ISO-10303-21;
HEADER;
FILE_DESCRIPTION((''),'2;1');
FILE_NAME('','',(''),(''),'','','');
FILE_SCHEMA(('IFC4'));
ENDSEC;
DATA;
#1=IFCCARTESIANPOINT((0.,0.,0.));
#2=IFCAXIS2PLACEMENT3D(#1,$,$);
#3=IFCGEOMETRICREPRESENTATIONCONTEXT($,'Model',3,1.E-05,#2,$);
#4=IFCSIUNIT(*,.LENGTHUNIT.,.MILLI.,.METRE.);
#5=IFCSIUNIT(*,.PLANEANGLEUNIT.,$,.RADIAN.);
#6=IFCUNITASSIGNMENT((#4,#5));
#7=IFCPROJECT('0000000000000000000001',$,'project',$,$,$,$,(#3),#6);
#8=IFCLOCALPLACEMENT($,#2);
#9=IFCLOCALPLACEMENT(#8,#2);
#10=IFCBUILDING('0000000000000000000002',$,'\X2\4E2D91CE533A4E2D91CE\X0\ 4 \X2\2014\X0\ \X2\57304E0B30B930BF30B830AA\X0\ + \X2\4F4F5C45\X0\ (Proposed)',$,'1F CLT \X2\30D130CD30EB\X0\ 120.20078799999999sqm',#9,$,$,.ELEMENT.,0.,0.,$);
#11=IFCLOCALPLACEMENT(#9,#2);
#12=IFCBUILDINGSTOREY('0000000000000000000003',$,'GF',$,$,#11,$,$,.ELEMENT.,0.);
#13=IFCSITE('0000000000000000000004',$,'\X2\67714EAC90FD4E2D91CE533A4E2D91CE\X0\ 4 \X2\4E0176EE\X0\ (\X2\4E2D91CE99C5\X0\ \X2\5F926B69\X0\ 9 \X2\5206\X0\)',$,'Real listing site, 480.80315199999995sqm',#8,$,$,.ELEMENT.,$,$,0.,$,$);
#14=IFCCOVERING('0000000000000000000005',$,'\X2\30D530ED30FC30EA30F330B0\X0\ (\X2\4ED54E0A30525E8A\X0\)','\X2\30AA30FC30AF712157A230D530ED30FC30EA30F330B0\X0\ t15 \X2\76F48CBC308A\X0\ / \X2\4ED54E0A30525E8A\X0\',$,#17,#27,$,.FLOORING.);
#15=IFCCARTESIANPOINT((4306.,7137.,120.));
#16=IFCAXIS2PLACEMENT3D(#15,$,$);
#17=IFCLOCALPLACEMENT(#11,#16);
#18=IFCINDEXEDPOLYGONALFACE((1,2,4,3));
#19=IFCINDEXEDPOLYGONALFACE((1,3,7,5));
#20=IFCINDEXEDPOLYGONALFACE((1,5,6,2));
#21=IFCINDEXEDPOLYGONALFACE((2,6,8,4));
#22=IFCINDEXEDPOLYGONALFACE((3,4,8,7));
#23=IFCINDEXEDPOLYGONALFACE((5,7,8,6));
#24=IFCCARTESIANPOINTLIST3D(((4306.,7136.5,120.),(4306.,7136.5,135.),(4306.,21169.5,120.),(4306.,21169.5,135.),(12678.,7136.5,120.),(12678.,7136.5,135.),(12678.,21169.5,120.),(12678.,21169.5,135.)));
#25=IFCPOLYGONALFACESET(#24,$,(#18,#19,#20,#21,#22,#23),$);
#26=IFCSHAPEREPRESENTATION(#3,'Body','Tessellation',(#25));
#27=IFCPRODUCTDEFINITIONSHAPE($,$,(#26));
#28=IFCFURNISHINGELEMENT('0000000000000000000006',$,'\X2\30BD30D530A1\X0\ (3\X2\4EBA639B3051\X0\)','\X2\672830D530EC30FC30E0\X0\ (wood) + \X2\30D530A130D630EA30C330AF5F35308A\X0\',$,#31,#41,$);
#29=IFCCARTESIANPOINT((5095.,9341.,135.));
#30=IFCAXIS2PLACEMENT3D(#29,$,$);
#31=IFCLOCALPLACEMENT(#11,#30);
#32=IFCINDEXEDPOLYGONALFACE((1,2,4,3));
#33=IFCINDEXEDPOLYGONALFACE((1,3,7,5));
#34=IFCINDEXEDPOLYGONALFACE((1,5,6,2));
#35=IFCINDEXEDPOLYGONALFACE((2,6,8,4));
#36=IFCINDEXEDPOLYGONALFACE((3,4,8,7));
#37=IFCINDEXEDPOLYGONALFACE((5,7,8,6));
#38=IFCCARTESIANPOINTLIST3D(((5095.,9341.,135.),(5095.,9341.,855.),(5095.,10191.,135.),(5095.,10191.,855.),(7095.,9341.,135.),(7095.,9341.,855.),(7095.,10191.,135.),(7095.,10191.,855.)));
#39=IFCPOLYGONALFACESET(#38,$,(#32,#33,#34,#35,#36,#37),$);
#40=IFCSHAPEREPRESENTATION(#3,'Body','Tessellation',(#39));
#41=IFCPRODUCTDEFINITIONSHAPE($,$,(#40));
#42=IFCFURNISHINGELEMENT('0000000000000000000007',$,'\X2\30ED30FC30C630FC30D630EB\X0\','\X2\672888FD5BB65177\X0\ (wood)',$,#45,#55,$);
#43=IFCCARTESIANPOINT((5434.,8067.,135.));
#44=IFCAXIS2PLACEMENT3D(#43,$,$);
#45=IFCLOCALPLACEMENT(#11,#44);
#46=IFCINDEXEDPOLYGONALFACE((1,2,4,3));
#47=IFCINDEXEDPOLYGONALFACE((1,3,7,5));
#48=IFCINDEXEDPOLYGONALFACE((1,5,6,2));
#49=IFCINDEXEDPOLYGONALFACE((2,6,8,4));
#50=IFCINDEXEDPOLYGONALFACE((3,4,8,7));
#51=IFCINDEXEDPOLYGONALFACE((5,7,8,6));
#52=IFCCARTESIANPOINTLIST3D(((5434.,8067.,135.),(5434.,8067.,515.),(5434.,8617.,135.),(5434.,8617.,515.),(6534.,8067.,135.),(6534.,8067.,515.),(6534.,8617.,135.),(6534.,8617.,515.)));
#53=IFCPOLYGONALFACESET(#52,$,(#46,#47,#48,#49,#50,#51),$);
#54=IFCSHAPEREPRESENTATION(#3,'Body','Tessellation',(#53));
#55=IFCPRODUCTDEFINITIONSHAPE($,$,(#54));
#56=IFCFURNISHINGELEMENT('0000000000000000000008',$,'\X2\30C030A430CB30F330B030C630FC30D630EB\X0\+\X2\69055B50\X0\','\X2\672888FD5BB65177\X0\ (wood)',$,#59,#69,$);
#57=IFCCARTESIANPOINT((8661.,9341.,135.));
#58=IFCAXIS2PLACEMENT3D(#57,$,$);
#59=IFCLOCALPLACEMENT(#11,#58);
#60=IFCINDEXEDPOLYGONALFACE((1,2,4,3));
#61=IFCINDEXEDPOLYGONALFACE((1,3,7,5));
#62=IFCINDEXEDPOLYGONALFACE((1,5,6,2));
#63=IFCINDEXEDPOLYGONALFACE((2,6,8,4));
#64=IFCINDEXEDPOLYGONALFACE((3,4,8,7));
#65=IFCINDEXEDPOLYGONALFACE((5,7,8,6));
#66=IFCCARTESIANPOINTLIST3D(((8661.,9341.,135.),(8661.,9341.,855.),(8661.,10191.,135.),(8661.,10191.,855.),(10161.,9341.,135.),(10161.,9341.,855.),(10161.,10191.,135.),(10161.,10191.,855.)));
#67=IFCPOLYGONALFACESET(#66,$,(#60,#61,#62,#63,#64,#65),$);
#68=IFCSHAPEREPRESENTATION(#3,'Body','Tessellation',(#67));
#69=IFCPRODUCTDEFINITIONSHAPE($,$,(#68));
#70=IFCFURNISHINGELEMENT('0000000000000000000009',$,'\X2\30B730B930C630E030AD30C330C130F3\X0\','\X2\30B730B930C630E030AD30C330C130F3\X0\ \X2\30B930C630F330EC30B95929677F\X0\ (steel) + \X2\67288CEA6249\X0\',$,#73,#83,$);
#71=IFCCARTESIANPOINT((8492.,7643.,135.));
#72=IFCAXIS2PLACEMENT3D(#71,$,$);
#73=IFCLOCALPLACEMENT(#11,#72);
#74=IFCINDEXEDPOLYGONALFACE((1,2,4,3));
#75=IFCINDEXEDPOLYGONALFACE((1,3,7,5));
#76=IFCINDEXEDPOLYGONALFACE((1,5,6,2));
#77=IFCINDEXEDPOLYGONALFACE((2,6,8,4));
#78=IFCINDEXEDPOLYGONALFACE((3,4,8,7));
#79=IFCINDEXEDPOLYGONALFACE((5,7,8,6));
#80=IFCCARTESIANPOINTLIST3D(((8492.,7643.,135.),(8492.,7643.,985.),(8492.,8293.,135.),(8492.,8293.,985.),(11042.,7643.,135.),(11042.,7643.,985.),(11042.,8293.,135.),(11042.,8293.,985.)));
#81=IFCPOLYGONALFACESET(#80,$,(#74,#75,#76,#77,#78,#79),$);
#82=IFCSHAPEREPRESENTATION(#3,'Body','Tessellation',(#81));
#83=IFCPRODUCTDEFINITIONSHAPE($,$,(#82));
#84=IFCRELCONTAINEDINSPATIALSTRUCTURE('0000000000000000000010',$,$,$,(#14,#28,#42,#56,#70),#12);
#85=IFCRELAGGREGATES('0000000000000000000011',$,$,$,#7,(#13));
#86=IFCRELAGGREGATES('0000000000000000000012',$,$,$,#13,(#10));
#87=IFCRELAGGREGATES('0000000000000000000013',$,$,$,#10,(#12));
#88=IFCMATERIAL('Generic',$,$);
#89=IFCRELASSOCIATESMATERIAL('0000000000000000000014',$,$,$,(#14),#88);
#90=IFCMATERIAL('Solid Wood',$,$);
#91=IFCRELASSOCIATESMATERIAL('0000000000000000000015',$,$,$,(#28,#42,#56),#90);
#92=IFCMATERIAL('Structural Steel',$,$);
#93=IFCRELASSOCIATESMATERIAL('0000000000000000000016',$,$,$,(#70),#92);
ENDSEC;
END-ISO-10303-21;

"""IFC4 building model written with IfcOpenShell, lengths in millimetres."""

from ifc_helpers import new_model, si_unit, frame, frame_2d, origin, place, context, project, spatial, rectangle, extrude, material, element, save


model = new_model("IFC4")

# Units and contexts
model_context = context("Model", 3, precision=1e-05, world=origin())
ifc_project = project(units=[si_unit("LENGTHUNIT", "METRE", prefix="MILLI"), si_unit("PLANEANGLEUNIT", "RADIAN")], contexts=[model_context])

# Site, building, storey
site_placement = place(None, origin())
site = spatial("IfcSite", under=ifc_project, at=site_placement, Name="東京都中野区中野 4 丁目 (中野駅 徒歩 9 分)", ObjectType="Real listing site, 480.80315199999995sqm", CompositionType="ELEMENT", RefElevation=0.0)
building_placement = place(site_placement, origin())
building = spatial("IfcBuilding", under=site, at=building_placement, Name="中野区中野 4 — 地下スタジオ + 住居 (Proposed)", ObjectType="1F CLT パネル 120.20078799999999sqm", CompositionType="ELEMENT", ElevationOfRefHeight=0.0, ElevationOfTerrain=0.0)
storey_placement = place(building_placement, origin())
storey = spatial("IfcBuildingStorey", under=building, at=storey_placement, Name="GF", CompositionType="ELEMENT", Elevation=0.0)

# Shared definitions
ifc_material_1 = material(Name="Solid Wood")

# Shared definitions
ifc_material_2 = material(Name="Structural Steel")

# Covering
ifc_material_3 = material(Name="Generic")
covering_placement = place(storey_placement, frame((4306.0, 7137.0, 120.0)))
element("IfcCovering", 1, at=covering_placement, inside=storey, material=ifc_material_3, Name="フローリング (仕上げ床)", Description="オーク無垢フローリング t15 直貼り / 仕上げ床", PredefinedType="FLOORING", context=model_context, shape_type="SweptSolid", body=[
    extrude(rectangle(XDim=8372.0, YDim=14033.0, at=frame_2d((4186.0, 7016.0))), frame((4306.0, 7137.0, 120.0)), (0.0, 0.0, 1.0), 15.0),
])

# Furnishing elements
furnishing_1_placement = place(storey_placement, frame((5095.0, 9341.0, 135.0)))
element("IfcFurnishingElement", 2, at=furnishing_1_placement, inside=storey, material=ifc_material_1, Name="ソファ (3人掛け)", Description="木フレーム (wood) + ファブリック張り", context=model_context, shape_type="SweptSolid", body=[
    extrude(rectangle(XDim=2000.0, YDim=850.0, at=frame_2d((1000.0, 425.0))), frame((5095.0, 9341.0, 135.0)), (0.0, 0.0, 1.0), 720.0),
])
furnishing_2_placement = place(storey_placement, frame((5434.0, 8067.0, 135.0)))
element("IfcFurnishingElement", 3, at=furnishing_2_placement, inside=storey, material=ifc_material_1, Name="ローテーブル", Description="木製家具 (wood)", context=model_context, shape_type="SweptSolid", body=[
    extrude(rectangle(XDim=1100.0, YDim=550.0, at=frame_2d((550.0, 275.0))), frame((5434.0, 8067.0, 135.0)), (0.0, 0.0, 1.0), 380.0),
])
furnishing_3_placement = place(storey_placement, frame((8661.0, 9341.0, 135.0)))
element("IfcFurnishingElement", 4, at=furnishing_3_placement, inside=storey, material=ifc_material_1, Name="ダイニングテーブル+椅子", Description="木製家具 (wood)", context=model_context, shape_type="SweptSolid", body=[
    extrude(rectangle(XDim=1500.0, YDim=850.0, at=frame_2d((750.0, 425.0))), frame((8661.0, 9341.0, 135.0)), (0.0, 0.0, 1.0), 720.0),
])
furnishing_4_placement = place(storey_placement, frame((8492.0, 7643.0, 135.0)))
element("IfcFurnishingElement", 5, at=furnishing_4_placement, inside=storey, material=ifc_material_2, Name="システムキッチン", Description="システムキッチン ステンレス天板 (steel) + 木質扉", context=model_context, shape_type="SweptSolid", body=[
    extrude(rectangle(XDim=2550.0, YDim=650.0, at=frame_2d((1275.0, 325.0))), frame((8492.0, 7643.0, 135.0)), (0.0, 0.0, 1.0), 850.0),
])

save(model, "model.ifc")
